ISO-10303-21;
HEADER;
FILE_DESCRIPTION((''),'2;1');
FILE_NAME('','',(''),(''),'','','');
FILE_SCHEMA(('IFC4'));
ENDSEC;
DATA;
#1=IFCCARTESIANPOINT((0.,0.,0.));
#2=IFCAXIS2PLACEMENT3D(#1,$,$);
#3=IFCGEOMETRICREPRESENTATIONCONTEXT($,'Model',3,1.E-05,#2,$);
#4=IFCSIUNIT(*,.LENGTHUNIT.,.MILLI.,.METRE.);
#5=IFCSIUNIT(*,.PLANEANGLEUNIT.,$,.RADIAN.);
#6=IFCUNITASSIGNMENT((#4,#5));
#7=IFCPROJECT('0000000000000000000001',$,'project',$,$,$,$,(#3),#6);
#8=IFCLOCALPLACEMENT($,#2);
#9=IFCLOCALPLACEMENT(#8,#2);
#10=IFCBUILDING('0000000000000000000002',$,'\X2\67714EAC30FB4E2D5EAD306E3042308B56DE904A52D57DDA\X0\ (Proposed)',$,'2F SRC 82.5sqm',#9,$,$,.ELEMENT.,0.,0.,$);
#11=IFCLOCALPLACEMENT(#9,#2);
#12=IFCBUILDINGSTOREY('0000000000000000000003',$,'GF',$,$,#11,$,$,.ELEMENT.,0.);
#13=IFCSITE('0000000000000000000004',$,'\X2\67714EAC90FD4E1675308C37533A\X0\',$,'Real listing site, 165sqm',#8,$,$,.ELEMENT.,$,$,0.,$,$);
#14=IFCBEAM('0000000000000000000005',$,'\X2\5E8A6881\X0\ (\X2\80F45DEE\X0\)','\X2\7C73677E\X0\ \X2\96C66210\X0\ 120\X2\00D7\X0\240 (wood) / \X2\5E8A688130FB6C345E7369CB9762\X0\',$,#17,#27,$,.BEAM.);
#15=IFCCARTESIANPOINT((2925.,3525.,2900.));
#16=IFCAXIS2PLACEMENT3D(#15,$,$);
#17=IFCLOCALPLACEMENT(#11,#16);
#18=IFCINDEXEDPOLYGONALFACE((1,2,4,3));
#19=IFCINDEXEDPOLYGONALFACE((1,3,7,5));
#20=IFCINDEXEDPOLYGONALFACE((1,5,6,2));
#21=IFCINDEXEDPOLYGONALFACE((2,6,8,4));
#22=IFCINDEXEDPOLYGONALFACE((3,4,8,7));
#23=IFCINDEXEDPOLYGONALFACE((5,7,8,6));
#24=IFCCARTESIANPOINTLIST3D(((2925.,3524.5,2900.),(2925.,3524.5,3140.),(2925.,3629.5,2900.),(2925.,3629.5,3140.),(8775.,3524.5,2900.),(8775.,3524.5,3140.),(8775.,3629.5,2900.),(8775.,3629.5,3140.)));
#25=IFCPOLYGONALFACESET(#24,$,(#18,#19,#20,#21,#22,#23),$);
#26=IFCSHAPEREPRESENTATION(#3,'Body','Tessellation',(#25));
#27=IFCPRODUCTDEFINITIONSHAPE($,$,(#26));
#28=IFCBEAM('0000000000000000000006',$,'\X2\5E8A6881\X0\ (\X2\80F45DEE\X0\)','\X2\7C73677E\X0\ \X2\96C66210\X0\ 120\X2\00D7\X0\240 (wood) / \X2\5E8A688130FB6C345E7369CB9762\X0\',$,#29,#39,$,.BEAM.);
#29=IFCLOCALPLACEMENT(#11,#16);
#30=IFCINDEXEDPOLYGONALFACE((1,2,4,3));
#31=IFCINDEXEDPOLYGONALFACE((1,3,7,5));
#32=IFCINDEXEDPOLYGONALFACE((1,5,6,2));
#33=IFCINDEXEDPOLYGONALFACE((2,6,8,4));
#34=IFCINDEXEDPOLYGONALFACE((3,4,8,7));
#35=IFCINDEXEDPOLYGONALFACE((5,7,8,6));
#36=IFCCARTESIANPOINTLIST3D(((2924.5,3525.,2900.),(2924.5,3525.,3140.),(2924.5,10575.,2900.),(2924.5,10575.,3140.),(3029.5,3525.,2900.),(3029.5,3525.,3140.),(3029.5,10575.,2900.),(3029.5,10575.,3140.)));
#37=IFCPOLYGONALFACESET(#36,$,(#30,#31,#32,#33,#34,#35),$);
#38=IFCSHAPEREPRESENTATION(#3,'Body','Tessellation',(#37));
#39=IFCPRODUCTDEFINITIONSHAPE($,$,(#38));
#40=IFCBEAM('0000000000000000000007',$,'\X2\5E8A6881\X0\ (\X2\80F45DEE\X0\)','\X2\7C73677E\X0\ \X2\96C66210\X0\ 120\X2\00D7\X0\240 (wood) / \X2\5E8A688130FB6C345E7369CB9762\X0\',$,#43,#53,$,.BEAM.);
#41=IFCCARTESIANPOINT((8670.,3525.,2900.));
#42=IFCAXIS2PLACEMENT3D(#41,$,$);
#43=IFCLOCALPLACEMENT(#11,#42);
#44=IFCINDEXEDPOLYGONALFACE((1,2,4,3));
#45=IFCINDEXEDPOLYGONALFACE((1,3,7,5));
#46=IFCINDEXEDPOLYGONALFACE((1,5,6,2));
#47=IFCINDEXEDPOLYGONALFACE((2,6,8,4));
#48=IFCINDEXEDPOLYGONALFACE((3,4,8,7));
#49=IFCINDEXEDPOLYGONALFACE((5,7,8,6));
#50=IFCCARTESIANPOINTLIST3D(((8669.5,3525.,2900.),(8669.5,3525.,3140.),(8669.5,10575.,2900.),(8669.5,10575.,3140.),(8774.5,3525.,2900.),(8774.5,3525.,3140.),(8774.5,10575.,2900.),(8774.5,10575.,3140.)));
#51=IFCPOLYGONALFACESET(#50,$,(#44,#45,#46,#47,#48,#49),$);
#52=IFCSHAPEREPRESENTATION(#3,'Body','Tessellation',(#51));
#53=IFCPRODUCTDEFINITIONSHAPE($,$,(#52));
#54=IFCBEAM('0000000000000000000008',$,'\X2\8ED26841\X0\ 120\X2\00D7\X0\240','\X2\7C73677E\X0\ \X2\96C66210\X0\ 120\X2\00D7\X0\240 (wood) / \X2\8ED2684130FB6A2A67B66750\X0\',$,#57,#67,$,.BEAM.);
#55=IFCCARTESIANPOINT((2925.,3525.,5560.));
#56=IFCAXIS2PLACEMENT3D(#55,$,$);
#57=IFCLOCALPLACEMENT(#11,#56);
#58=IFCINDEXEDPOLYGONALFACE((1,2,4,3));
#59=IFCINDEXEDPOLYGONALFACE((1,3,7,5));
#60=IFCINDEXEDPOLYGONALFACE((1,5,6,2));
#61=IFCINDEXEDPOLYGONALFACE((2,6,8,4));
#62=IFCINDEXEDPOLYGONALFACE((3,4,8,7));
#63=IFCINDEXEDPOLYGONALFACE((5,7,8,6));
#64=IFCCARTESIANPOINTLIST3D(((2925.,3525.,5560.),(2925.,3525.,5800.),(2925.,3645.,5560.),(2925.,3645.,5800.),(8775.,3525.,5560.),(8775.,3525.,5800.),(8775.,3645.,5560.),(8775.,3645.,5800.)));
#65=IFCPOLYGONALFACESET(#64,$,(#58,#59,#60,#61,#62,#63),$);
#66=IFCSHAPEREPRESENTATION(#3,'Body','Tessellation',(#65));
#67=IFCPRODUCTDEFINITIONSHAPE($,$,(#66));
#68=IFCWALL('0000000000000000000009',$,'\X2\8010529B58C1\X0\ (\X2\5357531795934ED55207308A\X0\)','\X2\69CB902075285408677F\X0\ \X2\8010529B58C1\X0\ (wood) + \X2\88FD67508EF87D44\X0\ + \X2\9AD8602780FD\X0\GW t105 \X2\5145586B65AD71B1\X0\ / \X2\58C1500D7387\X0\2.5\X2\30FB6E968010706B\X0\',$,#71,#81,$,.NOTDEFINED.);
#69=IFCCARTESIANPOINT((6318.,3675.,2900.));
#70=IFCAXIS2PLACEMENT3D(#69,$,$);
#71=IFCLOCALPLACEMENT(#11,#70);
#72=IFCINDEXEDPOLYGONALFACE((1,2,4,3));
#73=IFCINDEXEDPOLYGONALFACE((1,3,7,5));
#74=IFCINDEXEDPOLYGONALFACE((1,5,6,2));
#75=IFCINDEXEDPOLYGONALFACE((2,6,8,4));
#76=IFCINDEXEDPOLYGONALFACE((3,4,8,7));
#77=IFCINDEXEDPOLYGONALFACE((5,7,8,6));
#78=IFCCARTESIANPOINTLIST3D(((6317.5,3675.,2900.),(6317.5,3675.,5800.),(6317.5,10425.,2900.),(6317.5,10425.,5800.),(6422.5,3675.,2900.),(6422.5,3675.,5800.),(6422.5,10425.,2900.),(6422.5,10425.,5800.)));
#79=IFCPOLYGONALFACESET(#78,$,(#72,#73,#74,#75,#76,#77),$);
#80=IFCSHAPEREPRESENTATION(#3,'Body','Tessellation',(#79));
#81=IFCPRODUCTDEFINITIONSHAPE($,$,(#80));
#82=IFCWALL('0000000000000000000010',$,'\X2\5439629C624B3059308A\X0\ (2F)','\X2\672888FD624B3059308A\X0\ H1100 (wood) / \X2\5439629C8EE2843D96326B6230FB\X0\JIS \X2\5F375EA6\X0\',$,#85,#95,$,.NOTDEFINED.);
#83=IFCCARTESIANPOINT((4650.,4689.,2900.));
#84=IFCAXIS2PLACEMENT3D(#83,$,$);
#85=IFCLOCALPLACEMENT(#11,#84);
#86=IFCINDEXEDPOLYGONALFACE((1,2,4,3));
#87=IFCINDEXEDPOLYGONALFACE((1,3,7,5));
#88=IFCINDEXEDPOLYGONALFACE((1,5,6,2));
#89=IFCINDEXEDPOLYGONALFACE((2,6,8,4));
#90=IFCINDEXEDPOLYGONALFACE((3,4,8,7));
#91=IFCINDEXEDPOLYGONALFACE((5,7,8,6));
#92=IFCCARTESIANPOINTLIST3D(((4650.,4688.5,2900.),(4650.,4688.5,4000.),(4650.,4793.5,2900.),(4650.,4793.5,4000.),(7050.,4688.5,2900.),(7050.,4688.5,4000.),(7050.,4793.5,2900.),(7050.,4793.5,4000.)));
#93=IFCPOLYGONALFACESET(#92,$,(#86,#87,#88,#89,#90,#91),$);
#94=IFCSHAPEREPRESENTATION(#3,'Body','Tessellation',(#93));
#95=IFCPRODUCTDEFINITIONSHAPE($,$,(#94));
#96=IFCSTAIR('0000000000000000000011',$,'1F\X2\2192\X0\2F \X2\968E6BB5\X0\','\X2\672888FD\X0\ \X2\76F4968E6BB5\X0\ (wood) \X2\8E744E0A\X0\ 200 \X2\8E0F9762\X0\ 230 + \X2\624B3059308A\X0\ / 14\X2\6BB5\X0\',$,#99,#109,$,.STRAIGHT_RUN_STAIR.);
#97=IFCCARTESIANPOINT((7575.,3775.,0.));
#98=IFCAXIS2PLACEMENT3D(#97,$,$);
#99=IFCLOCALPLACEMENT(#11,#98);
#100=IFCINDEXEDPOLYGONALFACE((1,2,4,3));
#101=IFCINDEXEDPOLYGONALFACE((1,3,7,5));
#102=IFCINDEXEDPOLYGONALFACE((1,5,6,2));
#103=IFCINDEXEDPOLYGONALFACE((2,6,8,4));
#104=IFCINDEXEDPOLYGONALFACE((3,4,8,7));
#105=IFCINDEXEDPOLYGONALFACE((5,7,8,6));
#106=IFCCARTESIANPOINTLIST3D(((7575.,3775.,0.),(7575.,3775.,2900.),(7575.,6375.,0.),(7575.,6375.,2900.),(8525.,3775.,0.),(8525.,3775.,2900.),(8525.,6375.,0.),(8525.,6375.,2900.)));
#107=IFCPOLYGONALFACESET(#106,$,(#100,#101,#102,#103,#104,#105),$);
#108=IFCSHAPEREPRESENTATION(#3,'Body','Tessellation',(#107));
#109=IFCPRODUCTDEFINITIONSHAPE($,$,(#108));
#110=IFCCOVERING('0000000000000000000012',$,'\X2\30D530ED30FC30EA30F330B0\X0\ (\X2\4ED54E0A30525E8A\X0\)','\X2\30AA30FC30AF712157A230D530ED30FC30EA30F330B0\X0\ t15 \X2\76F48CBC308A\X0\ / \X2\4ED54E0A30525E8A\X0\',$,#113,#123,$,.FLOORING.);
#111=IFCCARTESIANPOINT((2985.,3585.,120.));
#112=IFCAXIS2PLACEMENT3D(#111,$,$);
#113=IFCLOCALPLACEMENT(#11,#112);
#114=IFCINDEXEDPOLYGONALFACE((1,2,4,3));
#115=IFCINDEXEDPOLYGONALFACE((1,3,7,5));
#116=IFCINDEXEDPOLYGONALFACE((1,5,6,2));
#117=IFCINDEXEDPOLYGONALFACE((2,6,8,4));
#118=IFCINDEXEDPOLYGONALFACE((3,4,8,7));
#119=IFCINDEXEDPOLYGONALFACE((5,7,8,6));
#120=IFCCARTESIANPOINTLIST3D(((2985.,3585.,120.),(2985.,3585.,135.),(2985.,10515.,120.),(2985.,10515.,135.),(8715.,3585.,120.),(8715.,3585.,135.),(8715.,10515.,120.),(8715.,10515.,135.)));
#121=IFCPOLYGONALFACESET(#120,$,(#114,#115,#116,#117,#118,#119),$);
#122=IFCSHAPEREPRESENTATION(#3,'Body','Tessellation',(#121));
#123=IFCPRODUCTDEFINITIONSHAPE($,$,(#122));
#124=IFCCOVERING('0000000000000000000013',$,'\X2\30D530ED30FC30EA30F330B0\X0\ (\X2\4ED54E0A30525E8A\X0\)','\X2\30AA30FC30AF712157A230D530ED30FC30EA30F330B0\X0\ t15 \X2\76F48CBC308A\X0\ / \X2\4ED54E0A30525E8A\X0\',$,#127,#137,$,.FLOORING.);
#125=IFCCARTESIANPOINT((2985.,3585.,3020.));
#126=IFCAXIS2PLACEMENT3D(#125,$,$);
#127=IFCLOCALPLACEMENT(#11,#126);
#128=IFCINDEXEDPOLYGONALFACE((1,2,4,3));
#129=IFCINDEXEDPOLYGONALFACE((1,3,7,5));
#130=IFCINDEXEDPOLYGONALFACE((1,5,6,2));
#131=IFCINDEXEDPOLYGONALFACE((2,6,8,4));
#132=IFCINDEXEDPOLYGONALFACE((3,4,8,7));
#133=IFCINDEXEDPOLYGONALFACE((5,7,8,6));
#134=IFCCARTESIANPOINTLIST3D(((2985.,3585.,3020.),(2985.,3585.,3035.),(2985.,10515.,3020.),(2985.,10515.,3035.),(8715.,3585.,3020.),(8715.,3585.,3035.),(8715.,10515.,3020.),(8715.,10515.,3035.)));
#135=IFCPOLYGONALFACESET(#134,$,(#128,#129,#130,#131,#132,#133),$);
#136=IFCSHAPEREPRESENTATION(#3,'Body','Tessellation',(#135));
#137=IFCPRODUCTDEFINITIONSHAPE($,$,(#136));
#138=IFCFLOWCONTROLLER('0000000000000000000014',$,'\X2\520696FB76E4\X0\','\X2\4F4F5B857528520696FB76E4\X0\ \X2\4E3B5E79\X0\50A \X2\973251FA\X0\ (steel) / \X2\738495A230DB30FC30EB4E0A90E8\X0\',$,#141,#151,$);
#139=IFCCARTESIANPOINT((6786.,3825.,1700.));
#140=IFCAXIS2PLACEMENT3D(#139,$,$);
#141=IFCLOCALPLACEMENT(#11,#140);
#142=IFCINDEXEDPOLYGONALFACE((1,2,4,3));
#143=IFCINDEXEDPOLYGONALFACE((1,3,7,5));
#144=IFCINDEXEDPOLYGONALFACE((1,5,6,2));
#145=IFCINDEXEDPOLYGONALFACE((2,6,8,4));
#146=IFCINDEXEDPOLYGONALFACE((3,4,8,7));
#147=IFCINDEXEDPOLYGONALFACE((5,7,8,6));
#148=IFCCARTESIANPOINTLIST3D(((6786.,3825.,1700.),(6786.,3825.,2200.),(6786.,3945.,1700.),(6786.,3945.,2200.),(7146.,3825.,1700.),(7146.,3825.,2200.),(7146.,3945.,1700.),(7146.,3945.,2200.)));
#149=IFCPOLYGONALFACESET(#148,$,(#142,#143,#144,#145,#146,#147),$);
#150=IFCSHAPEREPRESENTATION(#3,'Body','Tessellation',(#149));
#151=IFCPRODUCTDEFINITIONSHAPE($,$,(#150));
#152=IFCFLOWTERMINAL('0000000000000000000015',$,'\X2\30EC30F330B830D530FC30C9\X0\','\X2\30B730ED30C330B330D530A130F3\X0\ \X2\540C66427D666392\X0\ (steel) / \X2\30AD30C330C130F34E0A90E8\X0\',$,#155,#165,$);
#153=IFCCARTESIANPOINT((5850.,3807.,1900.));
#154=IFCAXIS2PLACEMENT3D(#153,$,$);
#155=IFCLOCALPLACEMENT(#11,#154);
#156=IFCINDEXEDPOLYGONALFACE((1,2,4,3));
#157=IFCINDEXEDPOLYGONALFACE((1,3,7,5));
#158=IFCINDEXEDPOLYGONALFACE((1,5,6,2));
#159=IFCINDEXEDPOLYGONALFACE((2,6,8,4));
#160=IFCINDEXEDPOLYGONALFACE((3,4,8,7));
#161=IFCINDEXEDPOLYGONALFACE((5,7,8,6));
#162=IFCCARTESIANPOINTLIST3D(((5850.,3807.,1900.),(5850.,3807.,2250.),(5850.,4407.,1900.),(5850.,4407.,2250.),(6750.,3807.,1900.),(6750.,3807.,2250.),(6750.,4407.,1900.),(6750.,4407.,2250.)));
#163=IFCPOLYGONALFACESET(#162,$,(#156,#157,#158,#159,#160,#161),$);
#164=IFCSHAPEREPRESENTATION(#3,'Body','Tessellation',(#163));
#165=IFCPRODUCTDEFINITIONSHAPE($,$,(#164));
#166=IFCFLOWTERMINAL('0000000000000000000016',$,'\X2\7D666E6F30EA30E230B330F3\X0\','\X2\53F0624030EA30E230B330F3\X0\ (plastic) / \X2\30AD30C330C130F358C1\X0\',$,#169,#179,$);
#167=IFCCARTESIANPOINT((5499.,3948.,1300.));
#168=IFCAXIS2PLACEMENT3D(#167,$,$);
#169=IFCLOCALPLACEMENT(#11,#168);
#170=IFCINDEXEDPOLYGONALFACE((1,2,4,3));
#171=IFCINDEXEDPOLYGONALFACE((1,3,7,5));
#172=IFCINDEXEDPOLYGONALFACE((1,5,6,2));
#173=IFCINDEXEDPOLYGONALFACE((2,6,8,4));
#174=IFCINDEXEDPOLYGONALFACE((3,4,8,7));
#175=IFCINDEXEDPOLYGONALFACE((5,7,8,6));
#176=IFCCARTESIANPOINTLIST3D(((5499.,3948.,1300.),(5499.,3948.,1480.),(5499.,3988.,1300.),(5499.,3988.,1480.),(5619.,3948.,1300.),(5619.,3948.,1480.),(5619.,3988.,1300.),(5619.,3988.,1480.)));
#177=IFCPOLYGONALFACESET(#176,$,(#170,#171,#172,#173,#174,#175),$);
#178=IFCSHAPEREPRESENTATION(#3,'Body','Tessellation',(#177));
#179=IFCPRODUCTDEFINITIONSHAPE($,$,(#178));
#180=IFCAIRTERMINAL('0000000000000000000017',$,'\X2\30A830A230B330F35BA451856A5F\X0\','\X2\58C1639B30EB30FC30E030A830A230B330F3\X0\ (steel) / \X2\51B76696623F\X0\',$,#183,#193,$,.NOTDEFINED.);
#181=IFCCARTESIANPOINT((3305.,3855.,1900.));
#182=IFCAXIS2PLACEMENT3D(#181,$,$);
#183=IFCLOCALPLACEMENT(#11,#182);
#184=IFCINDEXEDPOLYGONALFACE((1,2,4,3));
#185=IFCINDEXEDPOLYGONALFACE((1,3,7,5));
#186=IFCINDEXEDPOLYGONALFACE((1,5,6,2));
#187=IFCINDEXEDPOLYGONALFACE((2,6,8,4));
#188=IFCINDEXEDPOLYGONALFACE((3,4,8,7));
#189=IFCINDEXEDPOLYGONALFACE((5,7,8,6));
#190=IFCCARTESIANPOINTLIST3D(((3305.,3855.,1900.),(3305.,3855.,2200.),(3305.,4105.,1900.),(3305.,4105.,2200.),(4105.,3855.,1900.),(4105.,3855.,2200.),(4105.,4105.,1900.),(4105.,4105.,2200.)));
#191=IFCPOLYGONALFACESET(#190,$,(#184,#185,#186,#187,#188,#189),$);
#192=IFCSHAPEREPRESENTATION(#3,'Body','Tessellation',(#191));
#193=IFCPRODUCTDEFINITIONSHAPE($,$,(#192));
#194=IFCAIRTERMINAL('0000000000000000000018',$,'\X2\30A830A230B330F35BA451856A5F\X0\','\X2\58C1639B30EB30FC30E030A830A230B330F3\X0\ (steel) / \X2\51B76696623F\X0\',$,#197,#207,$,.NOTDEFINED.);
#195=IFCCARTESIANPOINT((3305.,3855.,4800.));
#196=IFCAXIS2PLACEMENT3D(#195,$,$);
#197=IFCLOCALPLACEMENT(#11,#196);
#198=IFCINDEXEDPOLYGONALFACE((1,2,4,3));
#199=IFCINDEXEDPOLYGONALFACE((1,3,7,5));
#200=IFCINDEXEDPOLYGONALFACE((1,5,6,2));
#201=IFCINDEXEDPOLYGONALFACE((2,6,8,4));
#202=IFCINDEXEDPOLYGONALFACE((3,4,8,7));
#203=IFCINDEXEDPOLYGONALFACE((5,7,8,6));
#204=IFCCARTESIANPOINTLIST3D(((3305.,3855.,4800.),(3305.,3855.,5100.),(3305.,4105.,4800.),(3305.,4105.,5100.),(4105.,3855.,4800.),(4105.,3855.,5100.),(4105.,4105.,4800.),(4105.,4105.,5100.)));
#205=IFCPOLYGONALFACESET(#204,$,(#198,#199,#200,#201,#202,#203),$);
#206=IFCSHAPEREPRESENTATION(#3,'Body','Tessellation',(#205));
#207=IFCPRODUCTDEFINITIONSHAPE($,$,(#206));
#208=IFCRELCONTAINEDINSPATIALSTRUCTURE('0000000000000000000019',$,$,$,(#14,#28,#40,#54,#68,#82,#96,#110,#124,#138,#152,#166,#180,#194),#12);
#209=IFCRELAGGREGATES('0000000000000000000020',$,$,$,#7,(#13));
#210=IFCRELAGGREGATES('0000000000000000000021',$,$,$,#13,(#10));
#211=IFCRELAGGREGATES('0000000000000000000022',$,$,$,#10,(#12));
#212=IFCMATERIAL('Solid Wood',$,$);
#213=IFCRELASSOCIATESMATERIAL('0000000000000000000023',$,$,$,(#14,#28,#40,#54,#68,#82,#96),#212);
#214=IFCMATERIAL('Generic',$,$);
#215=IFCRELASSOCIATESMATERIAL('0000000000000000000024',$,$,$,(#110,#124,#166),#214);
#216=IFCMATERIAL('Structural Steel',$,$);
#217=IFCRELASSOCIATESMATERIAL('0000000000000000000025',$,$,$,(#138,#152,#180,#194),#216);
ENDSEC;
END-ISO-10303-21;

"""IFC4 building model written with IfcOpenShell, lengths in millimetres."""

from ifc_helpers import new_model, si_unit, frame, frame_2d, origin, place, context, project, spatial, rectangle, extrude, material, element, save


model = new_model("IFC4")

# Units and contexts
model_context = context("Model", 3, precision=1e-05, world=origin())
ifc_project = project(units=[si_unit("LENGTHUNIT", "METRE", prefix="MILLI"), si_unit("PLANEANGLEUNIT", "RADIAN")], contexts=[model_context])

# Site, building, storey
site_placement = place(None, origin())
site = spatial("IfcSite", under=ifc_project, at=site_placement, Name="東京都世田谷区", ObjectType="Real listing site, 165sqm", CompositionType="ELEMENT", RefElevation=0.0)
building_placement = place(site_placement, origin())
building = spatial("IfcBuilding", under=site, at=building_placement, Name="東京・中庭のある回遊動線 (Proposed)", ObjectType="2F SRC 82.5sqm", CompositionType="ELEMENT", ElevationOfRefHeight=0.0, ElevationOfTerrain=0.0)
storey_placement = place(building_placement, origin())
storey = spatial("IfcBuildingStorey", under=building, at=storey_placement, Name="GF", CompositionType="ELEMENT", Elevation=0.0)

# Shared definitions
ifc_material_1 = material(Name="Solid Wood")

# Beams
beam_1_placement = place(storey_placement, frame((2925.0, 3525.0, 2900.0)))
element("IfcBeam", 1, at=beam_1_placement, inside=storey, material=ifc_material_1, Name="床梁 (胴差)", Description="米松 集成 120×240 (wood) / 床梁・水平構面", PredefinedType="BEAM", context=model_context, shape_type="SweptSolid", body=[
    extrude(rectangle(XDim=5850.0, YDim=105.0, at=frame_2d((2925.0, 52.0))), frame((2925.0, 3525.0, 2900.0)), (0.0, 0.0, 1.0), 240.0),
])
beam_2_placement = place(storey_placement, frame((2925.0, 3525.0, 2900.0)))
element("IfcBeam", 2, at=beam_2_placement, inside=storey, material=ifc_material_1, Name="床梁 (胴差)", Description="米松 集成 120×240 (wood) / 床梁・水平構面", PredefinedType="BEAM", context=model_context, shape_type="SweptSolid", body=[
    extrude(rectangle(XDim=105.0, YDim=7050.0, at=frame_2d((52.0, 3525.0))), frame((2925.0, 3525.0, 2900.0)), (0.0, 0.0, 1.0), 240.0),
])
beam_3_placement = place(storey_placement, frame((8670.0, 3525.0, 2900.0)))
element("IfcBeam", 3, at=beam_3_placement, inside=storey, material=ifc_material_1, Name="床梁 (胴差)", Description="米松 集成 120×240 (wood) / 床梁・水平構面", PredefinedType="BEAM", context=model_context, shape_type="SweptSolid", body=[
    extrude(rectangle(XDim=105.0, YDim=7050.0, at=frame_2d((52.0, 3525.0))), frame((8670.0, 3525.0, 2900.0)), (0.0, 0.0, 1.0), 240.0),
])
beam_4_placement = place(storey_placement, frame((2925.0, 3525.0, 5560.0)))
element("IfcBeam", 4, at=beam_4_placement, inside=storey, material=ifc_material_1, Name="軒桁 120×240", Description="米松 集成 120×240 (wood) / 軒桁・横架材", PredefinedType="BEAM", context=model_context, shape_type="SweptSolid", body=[
    extrude(rectangle(XDim=5850.0, YDim=120.0, at=frame_2d((2925.0, 60.0))), frame((2925.0, 3525.0, 5560.0)), (0.0, 0.0, 1.0), 240.0),
])

# Walls
wall_1_placement = place(storey_placement, frame((6318.0, 3675.0, 2900.0)))
element("IfcWall", 5, at=wall_1_placement, inside=storey, material=ifc_material_1, Name="耐力壁 (南北間仕切り)", Description="構造用合板 耐力壁 (wood) + 製材軸組 + 高性能GW t105 充填断熱 / 壁倍率2.5・準耐火", PredefinedType="NOTDEFINED", context=model_context, shape_type="SweptSolid", body=[
    extrude(rectangle(XDim=105.0, YDim=6750.0, at=frame_2d((52.0, 3375.0))), frame((6318.0, 3675.0, 2900.0)), (0.0, 0.0, 1.0), 2900.0),
])
wall_2_placement = place(storey_placement, frame((4650.0, 4689.0, 2900.0)))
element("IfcWall", 6, at=wall_2_placement, inside=storey, material=ifc_material_1, Name="吹抜手すり (2F)", Description="木製手すり H1100 (wood) / 吹抜転落防止・JIS 強度", PredefinedType="NOTDEFINED", context=model_context, shape_type="SweptSolid", body=[
    extrude(rectangle(XDim=2400.0, YDim=105.0, at=frame_2d((1200.0, 52.0))), frame((4650.0, 4689.0, 2900.0)), (0.0, 0.0, 1.0), 1100.0),
])

# Stair
stair_placement = place(storey_placement, frame((7575.0, 3775.0, 0.0)))
element("IfcStair", 7, at=stair_placement, inside=storey, material=ifc_material_1, Name="1F→2F 階段", Description="木製 直階段 (wood) 蹴上 200 踏面 230 + 手すり / 14段", PredefinedType="STRAIGHT_RUN_STAIR", context=model_context, shape_type="SweptSolid", body=[
    extrude(rectangle(XDim=950.0, YDim=2600.0, at=frame_2d((475.0, 1300.0))), frame((7575.0, 3775.0, 0.0)), (0.0, 0.0, 1.0), 2900.0),
])

# Coverings
ifc_material_2 = material(Name="Generic")
covering_1_placement = place(storey_placement, frame((2985.0, 3585.0, 120.0)))
element("IfcCovering", 8, at=covering_1_placement, inside=storey, material=ifc_material_2, Name="フローリング (仕上げ床)", Description="オーク無垢フローリング t15 直貼り / 仕上げ床", PredefinedType="FLOORING", context=model_context, shape_type="SweptSolid", body=[
    extrude(rectangle(XDim=5730.0, YDim=6930.0, at=frame_2d((2865.0, 3465.0))), frame((2985.0, 3585.0, 120.0)), (0.0, 0.0, 1.0), 15.0),
])
covering_2_placement = place(storey_placement, frame((2985.0, 3585.0, 3020.0)))
element("IfcCovering", 9, at=covering_2_placement, inside=storey, material=ifc_material_2, Name="フローリング (仕上げ床)", Description="オーク無垢フローリング t15 直貼り / 仕上げ床", PredefinedType="FLOORING", context=model_context, shape_type="SweptSolid", body=[
    extrude(rectangle(XDim=5730.0, YDim=6930.0, at=frame_2d((2865.0, 3465.0))), frame((2985.0, 3585.0, 3020.0)), (0.0, 0.0, 1.0), 15.0),
])

# Flow controller
ifc_material_3 = material(Name="Structural Steel")
flow_controller_placement = place(storey_placement, frame((6786.0, 3825.0, 1700.0)))
element("IfcFlowController", 10, at=flow_controller_placement, inside=storey, material=ifc_material_3, Name="分電盤", Description="住宅用分電盤 主幹50A 露出 (steel) / 玄関ホール上部", context=model_context, shape_type="SweptSolid", body=[
    extrude(rectangle(XDim=360.0, YDim=120.0, at=frame_2d((180.0, 60.0))), frame((6786.0, 3825.0, 1700.0)), (0.0, 0.0, 1.0), 500.0),
])

# Flow terminals
flow_terminal_1_placement = place(storey_placement, frame((5850.0, 3807.0, 1900.0)))
element("IfcFlowTerminal", 11, at=flow_terminal_1_placement, inside=storey, material=ifc_material_3, Name="レンジフード", Description="シロッコファン 同時給排 (steel) / キッチン上部", context=model_context, shape_type="SweptSolid", body=[
    extrude(rectangle(XDim=900.0, YDim=600.0, at=frame_2d((450.0, 300.0))), frame((5850.0, 3807.0, 1900.0)), (0.0, 0.0, 1.0), 350.0),
])
flow_terminal_2_placement = place(storey_placement, frame((5499.0, 3948.0, 1300.0)))
element("IfcFlowTerminal", 12, at=flow_terminal_2_placement, inside=storey, material=ifc_material_2, Name="給湯リモコン", Description="台所リモコン (plastic) / キッチン壁", context=model_context, shape_type="SweptSolid", body=[
    extrude(rectangle(XDim=120.0, YDim=40.0, at=frame_2d((60.0, 20.0))), frame((5499.0, 3948.0, 1300.0)), (0.0, 0.0, 1.0), 180.0),
])

# Air terminals
air_terminal_1_placement = place(storey_placement, frame((3305.0, 3855.0, 1900.0)))
element("IfcAirTerminal", 13, at=air_terminal_1_placement, inside=storey, material=ifc_material_3, Name="エアコン室内機", Description="壁掛ルームエアコン (steel) / 冷暖房", PredefinedType="NOTDEFINED", context=model_context, shape_type="SweptSolid", body=[
    extrude(rectangle(XDim=800.0, YDim=250.0, at=frame_2d((400.0, 125.0))), frame((3305.0, 3855.0, 1900.0)), (0.0, 0.0, 1.0), 300.0),
])
air_terminal_2_placement = place(storey_placement, frame((3305.0, 3855.0, 4800.0)))
element("IfcAirTerminal", 14, at=air_terminal_2_placement, inside=storey, material=ifc_material_3, Name="エアコン室内機", Description="壁掛ルームエアコン (steel) / 冷暖房", PredefinedType="NOTDEFINED", context=model_context, shape_type="SweptSolid", body=[
    extrude(rectangle(XDim=800.0, YDim=250.0, at=frame_2d((400.0, 125.0))), frame((3305.0, 3855.0, 4800.0)), (0.0, 0.0, 1.0), 300.0),
])

save(model, "model.ifc")
